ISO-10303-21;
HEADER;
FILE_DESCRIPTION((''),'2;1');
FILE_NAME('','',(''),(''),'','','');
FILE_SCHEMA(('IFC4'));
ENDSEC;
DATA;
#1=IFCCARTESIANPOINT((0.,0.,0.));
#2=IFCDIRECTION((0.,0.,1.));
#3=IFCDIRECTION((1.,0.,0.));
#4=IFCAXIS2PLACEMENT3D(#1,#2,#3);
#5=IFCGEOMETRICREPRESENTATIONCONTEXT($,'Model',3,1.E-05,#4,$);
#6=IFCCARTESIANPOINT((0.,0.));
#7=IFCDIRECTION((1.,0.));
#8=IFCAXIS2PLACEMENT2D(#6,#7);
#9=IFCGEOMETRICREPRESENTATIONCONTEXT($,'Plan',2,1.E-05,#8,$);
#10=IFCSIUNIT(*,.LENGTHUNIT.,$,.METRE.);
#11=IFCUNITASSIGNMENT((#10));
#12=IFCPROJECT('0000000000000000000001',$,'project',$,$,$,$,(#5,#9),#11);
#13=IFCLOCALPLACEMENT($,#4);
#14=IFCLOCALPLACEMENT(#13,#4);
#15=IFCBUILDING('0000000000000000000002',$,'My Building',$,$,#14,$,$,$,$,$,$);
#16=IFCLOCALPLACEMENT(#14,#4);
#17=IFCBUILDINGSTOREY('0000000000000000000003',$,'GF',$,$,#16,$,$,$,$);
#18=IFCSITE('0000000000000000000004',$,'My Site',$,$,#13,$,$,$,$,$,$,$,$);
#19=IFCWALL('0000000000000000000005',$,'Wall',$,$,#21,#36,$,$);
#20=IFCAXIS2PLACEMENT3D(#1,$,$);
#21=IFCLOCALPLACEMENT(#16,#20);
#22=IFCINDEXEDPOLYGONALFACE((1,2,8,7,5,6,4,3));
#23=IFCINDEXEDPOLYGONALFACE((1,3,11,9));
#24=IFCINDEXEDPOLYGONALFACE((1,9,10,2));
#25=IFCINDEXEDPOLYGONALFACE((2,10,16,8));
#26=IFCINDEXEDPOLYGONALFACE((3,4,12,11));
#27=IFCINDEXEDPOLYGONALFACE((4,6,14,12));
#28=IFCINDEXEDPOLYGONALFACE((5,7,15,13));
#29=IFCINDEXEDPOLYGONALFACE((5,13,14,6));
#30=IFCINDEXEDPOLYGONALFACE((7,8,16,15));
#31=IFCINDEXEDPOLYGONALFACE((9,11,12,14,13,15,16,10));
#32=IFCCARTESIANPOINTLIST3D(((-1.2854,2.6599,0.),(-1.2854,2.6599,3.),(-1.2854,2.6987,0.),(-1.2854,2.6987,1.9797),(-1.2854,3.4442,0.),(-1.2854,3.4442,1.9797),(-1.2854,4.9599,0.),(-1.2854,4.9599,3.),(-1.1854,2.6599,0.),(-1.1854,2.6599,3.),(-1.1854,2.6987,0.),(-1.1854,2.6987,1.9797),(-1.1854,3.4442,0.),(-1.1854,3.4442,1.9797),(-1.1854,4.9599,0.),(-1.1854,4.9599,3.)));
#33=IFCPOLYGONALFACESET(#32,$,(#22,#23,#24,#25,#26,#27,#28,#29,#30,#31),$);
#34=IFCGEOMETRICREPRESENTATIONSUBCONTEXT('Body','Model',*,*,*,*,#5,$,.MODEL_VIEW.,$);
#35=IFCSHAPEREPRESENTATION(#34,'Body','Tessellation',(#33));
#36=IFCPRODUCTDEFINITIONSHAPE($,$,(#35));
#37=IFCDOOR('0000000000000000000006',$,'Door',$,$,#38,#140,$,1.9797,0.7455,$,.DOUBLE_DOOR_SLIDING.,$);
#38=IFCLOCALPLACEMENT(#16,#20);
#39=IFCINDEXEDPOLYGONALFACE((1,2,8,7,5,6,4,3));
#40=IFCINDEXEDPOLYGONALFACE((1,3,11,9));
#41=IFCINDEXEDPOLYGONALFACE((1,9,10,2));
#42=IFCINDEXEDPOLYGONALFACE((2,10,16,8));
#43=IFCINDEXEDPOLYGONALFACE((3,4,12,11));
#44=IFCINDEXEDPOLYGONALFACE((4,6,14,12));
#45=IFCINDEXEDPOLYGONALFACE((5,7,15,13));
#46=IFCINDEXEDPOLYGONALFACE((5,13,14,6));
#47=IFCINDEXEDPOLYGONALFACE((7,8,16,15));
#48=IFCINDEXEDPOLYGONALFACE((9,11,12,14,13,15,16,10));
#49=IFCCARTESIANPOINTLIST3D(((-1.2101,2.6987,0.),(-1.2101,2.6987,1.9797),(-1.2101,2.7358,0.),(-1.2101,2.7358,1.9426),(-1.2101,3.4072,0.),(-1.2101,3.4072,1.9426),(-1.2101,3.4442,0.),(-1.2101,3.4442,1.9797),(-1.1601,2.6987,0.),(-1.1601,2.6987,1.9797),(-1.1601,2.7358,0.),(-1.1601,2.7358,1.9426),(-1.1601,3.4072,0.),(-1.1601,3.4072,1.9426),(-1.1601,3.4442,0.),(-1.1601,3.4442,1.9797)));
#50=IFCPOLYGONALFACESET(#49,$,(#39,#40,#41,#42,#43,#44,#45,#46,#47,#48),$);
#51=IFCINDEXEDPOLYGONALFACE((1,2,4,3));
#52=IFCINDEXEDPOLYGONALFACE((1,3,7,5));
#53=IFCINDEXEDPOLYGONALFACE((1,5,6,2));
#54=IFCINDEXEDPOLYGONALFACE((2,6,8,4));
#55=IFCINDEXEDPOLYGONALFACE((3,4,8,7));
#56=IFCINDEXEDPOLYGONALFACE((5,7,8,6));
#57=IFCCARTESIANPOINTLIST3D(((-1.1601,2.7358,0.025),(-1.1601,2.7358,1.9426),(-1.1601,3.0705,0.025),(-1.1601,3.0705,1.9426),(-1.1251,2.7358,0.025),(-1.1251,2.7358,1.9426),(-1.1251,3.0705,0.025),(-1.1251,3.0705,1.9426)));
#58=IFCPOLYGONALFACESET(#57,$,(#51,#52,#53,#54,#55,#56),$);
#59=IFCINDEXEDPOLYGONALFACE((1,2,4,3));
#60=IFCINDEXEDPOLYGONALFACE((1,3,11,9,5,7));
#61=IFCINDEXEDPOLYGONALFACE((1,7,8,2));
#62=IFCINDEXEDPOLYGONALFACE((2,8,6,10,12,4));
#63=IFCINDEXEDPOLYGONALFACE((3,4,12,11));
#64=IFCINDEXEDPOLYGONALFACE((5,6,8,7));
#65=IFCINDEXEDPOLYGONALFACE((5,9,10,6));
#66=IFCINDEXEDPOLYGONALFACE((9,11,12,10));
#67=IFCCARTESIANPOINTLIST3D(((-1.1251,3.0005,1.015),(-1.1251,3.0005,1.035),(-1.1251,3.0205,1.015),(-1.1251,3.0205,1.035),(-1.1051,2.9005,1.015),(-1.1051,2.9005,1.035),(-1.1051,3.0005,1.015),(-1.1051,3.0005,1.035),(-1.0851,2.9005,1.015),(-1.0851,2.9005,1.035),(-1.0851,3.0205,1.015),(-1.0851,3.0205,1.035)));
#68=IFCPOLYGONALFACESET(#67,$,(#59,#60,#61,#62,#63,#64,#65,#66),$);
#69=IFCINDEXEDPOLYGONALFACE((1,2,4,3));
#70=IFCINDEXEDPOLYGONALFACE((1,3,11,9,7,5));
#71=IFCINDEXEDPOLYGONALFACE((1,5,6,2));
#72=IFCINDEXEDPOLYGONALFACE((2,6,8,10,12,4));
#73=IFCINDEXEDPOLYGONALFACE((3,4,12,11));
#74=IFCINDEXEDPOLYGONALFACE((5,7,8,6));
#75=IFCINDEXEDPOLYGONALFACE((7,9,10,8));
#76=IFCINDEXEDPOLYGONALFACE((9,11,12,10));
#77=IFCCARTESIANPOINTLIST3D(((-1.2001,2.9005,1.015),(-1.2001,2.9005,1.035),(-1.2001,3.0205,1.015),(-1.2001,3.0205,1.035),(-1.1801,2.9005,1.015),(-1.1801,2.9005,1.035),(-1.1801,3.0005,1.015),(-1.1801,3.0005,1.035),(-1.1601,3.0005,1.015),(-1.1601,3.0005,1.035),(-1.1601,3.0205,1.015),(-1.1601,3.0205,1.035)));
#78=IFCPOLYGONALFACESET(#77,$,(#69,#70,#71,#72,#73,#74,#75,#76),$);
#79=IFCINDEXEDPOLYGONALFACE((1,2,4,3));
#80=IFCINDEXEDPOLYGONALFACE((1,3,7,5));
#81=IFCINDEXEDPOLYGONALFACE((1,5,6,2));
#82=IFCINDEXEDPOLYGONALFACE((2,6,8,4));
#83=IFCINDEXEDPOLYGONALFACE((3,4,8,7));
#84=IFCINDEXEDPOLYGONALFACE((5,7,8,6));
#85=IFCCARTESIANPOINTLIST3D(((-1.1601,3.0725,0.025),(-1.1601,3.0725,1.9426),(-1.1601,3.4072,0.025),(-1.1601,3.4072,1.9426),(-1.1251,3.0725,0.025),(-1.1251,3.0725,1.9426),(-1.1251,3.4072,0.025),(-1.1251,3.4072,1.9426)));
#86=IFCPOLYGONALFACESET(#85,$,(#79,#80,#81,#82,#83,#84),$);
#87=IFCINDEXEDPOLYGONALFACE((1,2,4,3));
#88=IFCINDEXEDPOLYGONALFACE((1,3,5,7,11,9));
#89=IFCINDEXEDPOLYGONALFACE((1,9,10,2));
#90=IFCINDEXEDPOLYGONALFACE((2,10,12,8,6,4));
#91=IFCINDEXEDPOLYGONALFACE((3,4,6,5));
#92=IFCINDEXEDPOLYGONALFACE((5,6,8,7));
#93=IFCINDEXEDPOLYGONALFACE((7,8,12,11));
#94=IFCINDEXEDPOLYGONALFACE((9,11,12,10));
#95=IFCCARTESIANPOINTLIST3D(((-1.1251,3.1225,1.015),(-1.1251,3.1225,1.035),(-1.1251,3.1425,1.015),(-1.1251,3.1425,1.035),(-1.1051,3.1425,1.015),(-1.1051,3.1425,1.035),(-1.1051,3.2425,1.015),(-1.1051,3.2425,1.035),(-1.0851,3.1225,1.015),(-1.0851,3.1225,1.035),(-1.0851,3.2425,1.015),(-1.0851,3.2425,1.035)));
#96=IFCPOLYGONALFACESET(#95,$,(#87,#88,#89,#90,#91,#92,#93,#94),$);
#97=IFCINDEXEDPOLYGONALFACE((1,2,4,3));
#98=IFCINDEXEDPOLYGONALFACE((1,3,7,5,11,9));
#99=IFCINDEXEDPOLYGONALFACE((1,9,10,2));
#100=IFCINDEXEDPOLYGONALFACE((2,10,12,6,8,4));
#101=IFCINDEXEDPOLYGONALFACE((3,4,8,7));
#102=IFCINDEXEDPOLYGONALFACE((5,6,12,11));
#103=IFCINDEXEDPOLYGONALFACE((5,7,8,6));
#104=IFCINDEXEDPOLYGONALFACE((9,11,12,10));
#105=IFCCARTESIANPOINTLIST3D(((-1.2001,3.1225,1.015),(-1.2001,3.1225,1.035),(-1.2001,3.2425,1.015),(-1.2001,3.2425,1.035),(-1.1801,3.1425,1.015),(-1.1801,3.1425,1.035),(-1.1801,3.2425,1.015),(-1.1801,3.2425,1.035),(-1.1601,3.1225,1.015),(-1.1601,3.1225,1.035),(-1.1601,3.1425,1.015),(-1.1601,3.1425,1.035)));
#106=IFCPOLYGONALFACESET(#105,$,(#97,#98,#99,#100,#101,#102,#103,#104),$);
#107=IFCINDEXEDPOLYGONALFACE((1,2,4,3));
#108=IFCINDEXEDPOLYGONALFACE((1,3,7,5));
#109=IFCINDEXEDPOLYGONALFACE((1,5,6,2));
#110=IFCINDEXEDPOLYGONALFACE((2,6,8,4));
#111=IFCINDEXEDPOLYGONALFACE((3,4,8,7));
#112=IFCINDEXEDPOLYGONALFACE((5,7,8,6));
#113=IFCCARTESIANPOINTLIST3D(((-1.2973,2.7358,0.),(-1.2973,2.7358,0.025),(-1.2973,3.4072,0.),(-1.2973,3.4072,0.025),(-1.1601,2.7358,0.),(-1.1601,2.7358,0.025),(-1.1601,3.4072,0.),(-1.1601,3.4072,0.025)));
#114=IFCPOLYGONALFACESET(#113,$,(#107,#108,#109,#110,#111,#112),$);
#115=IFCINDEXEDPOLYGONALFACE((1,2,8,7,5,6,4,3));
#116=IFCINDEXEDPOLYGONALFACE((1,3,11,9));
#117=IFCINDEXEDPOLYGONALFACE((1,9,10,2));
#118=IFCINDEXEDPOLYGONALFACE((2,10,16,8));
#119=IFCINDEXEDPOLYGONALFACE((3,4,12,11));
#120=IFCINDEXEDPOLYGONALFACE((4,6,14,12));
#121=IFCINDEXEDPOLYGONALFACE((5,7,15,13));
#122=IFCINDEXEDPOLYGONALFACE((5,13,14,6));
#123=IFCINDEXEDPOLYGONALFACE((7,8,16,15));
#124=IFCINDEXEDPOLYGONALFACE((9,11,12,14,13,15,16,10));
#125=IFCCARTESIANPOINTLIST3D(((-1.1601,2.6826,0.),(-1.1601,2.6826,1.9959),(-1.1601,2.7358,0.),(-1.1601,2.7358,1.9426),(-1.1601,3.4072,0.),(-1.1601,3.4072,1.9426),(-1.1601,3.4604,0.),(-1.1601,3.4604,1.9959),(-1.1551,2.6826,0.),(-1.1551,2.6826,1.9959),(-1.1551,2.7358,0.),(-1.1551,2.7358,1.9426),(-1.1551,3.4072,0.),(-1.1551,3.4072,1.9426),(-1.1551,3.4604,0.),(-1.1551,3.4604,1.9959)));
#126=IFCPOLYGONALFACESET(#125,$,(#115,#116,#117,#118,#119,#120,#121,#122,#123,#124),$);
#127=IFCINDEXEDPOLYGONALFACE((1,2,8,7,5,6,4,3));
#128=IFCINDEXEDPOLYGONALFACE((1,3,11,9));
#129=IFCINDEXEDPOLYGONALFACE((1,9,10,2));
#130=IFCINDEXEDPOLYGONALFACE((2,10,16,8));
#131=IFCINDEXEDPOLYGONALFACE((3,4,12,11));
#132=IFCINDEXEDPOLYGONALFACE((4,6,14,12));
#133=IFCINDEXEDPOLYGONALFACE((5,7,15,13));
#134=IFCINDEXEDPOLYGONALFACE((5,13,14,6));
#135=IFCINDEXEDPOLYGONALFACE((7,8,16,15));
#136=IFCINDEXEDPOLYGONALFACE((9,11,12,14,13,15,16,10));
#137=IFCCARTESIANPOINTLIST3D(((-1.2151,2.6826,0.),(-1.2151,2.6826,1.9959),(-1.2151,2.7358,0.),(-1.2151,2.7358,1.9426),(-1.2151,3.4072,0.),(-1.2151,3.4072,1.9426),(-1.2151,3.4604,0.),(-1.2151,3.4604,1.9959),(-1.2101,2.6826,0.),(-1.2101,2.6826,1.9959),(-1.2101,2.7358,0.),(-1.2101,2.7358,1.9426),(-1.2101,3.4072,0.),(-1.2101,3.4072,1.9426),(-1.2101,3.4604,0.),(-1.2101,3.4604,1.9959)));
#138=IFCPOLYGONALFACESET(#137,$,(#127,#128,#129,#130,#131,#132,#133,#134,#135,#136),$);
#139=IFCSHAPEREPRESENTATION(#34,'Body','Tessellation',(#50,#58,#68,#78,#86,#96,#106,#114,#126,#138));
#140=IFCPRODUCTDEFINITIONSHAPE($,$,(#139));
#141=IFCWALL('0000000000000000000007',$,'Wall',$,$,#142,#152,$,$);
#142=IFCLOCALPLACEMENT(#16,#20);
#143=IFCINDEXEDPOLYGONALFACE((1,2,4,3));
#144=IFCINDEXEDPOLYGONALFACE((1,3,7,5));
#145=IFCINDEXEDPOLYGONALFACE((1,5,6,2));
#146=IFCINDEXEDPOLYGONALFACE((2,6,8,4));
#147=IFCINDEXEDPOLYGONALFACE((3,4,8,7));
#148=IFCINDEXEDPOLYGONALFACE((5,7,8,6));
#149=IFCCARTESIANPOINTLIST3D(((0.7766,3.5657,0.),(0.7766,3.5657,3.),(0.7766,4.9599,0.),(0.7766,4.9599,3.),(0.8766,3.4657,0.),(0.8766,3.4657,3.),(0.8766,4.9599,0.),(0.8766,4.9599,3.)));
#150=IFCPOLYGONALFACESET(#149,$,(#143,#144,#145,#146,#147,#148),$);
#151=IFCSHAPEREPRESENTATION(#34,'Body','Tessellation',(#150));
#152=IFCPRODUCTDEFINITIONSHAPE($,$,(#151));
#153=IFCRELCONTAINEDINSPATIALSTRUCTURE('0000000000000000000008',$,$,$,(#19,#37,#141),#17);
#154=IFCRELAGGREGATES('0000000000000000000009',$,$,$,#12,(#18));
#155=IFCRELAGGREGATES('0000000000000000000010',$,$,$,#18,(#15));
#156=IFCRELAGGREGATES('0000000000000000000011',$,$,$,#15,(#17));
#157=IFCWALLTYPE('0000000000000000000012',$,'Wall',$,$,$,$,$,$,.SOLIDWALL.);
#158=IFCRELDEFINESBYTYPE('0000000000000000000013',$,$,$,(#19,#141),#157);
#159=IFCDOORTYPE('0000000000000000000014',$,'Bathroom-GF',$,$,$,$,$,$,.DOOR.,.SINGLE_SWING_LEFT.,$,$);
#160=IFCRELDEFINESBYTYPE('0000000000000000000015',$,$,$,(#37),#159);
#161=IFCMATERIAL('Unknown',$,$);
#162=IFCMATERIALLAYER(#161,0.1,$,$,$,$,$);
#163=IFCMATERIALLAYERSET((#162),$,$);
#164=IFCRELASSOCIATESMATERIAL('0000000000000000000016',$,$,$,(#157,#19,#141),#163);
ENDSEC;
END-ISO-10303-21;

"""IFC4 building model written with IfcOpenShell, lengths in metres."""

from ifc_helpers import new_model, entity, si_unit, frame, origin_with_axes, origin_2d_with_axis, place, context, subcontext, project, spatial, line, indexed_curve, outline, extrude, shape, source, transform, mapped, material, layer, layer_set, layer_usage, type_object, type_shapes, element, fill, save


model = new_model("IFC4")

# Units and contexts
model_context = context("Model", 3, precision=1e-05, world=origin_with_axes())
plan_context = context("Plan", 2, precision=1e-05, world=origin_2d_with_axis())
body_context_1 = subcontext(model_context, "Body", "Model", "MODEL_VIEW")
body_context_2 = subcontext(plan_context, "Body", "Plan", "PLAN_VIEW")
ifc_project = project(units=[si_unit("LENGTHUNIT", "METRE")], contexts=[model_context, plan_context])

# Site, building, storey
site_placement = place(None, origin_with_axes())
site = spatial("IfcSite", under=ifc_project, at=site_placement, Name="My Site")
building_placement = place(site_placement, origin_with_axes())
building = spatial("IfcBuilding", under=site, at=building_placement, Name="My Building")
storey_placement = place(building_placement, origin_with_axes())
storey = spatial("IfcBuildingStorey", under=building, at=storey_placement, Name="GF")

# Shared definitions
ifc_material = material(Name="Unknown")

# Shared definitions
ifc_layer_1 = layer(ifc_material, 0.1)
ifc_layer_set_1 = layer_set([ifc_layer_1])
wall_type = type_object("IfcWallType", Name="Wall", PredefinedType="SOLIDWALL", material=ifc_layer_set_1)

# Wall, opening, door
ifc_layer_usage_1 = layer_usage(ifc_layer_set_1, "AXIS2", "POSITIVE", 0.0)
wall_1_placement = place(storey_placement, frame((-1.1854, 2.6599, 0.0), z_axis=(0.0, 0.0, 1.0), x_axis=(0.0, 1.0, 0.0)))
wall_1 = element("IfcWall", 1, at=wall_1_placement, inside=storey, type_object=wall_type, material=ifc_layer_usage_1, Name="Wall", context=body_context_1, shape_type="SweptSolid", body=[
    extrude(outline(indexed_curve([(0.0, 0.0), (0.0, 0.1), (2.3, 0.1), (2.3, 0.0)], segments=[line(1, 2, 3, 4, 1)])), origin_with_axes(), (0.0, 0.0, 1.0), 3.0),
])
shared_shape_1 = source(origin_with_axes(), body_context_1, "Body", "SweptSolid", [
    extrude(outline(indexed_curve([(0.0, 0.0), (0.7455, 0.0), (0.7455, 1.9797), (0.0, 1.9797)], segments=[line(1, 2, 3, 4, 1)])), frame((0.0, -0.6, 0.0), z_axis=(0.0, -1.0, 0.0), x_axis=(1.0, 0.0, 0.0)), (0.0, 0.0, -1.0), 1.2),
])
opening_1_placement = place(wall_1_placement, frame((0.0388, -0.0253, 0.0), z_axis=(0.0, 0.0, 1.0), x_axis=(1.0, 0.0, 0.0)))
opening_1 = element("IfcOpeningElement", 2, at=opening_1_placement, cuts=wall_1, PredefinedType="OPENING", context=body_context_1, shape_type="MappedRepresentation", body=[
    mapped(shared_shape_1, transform((0.0, 0.0, 0.0), x_axis=(1.0, 0.0, 0.0), y_axis=(0.0, 1.0, 0.0), z_axis=(0.0, 0.0, 1.0), scale=1.0)),
])
door_type_1 = type_object("IfcDoorType", Name="Bathroom-GF", OperationType="SINGLE_SWING_LEFT", PredefinedType="DOOR")
shared_shape_2 = source(origin_with_axes(), body_context_1, "Body", "SweptSolid", [
    extrude(outline(indexed_curve([(0.0, 0.0), (0.0, 1.9797), (0.7455, 1.9797), (0.7455, 0.0), (0.7084, 0.0), (0.7084, 1.9426), (0.0371, 1.9426), (0.0371, 0.0)], segments=[line(1, 2, 3, 4, 5, 6, 7, 8, 1)])), frame((0.0, 0.0, 0.0), z_axis=(0.0, -1.0, 0.0), x_axis=(1.0, 0.0, 0.0)), (0.0, 0.0, -1.0), 0.05),
    extrude(outline(indexed_curve([(0.0, 0.0), (0.3347, 0.0), (0.3347, 0.035), (0.0, 0.035)], segments=[line(1, 2, 3, 4, 1)])), frame((0.0371, -0.035, 0.025), z_axis=(0.0, 0.0, 1.0), x_axis=(1.0, 0.0, 0.0)), (0.0, 0.0, 1.0), 1.9176),
    extrude(outline(indexed_curve([(0.0, 0.0), (0.0, -0.04), (-0.12, -0.04), (-0.12, -0.02), (-0.02, -0.02), (-0.02, 0.0)], segments=[line(1, 2, 3, 4, 5, 6, 1)])), frame((0.3218, -0.035, 1.015), z_axis=(0.0, 0.0, 1.0), x_axis=(1.0, 0.0, 0.0)), (0.0, 0.0, 1.0), 0.02),
    extrude(outline(indexed_curve([(0.0, 0.0), (0.0, 0.04), (-0.12, 0.04), (-0.12, 0.02), (-0.02, 0.02), (-0.02, 0.0)], segments=[line(1, 2, 3, 4, 5, 6, 1)])), frame((0.3218, 0.0, 1.015), z_axis=(0.0, 0.0, 1.0), x_axis=(1.0, 0.0, 0.0)), (0.0, 0.0, 1.0), 0.02),
    extrude(outline(indexed_curve([(0.0, 0.0), (-0.3347, 0.0), (-0.3347, 0.035), (0.0, 0.035)], segments=[line(1, 2, 3, 4, 1)])), frame((0.7084, -0.035, 0.025), z_axis=(0.0, 0.0, 1.0), x_axis=(1.0, 0.0, 0.0)), (0.0, 0.0, 1.0), 1.9176),
    extrude(outline(indexed_curve([(0.0, 0.0), (0.0, -0.04), (0.12, -0.04), (0.12, -0.02), (0.02, -0.02), (0.02, 0.0)], segments=[line(1, 2, 3, 4, 5, 6, 1)])), frame((0.4238, -0.035, 1.015), z_axis=(0.0, 0.0, 1.0), x_axis=(1.0, 0.0, 0.0)), (0.0, 0.0, 1.0), 0.02),
    extrude(outline(indexed_curve([(0.0, 0.0), (0.0, 0.04), (0.12, 0.04), (0.12, 0.02), (0.02, 0.02), (0.02, 0.0)], segments=[line(1, 2, 3, 4, 5, 6, 1)])), frame((0.4238, 0.0, 1.015), z_axis=(0.0, 0.0, 1.0), x_axis=(1.0, 0.0, 0.0)), (0.0, 0.0, 1.0), 0.02),
    extrude(outline(indexed_curve([(0.0, 0.0), (0.6713, 0.0), (0.6713, 0.1372), (0.0, 0.1372)], segments=[line(1, 2, 3, 4, 1)])), frame((0.0371, 0.0, 0.0), z_axis=(0.0, 0.0, 1.0), x_axis=(1.0, 0.0, 0.0)), (0.0, 0.0, 1.0), 0.025),
    extrude(outline(indexed_curve([(0.0, 0.0), (0.0, 1.9959), (0.7778, 1.9959), (0.7778, 0.0), (0.7246, 0.0), (0.7246, 1.9426), (0.0532, 1.9426), (0.0532, 0.0)], segments=[line(1, 2, 3, 4, 5, 6, 7, 8, 1)])), frame((-0.0162, -0.005, 0.0), z_axis=(0.0, -1.0, 0.0), x_axis=(1.0, 0.0, 0.0)), (0.0, 0.0, -1.0), 0.005),
    extrude(outline(indexed_curve([(0.0, 0.0), (0.0, 1.9959), (0.7778, 1.9959), (0.7778, 0.0), (0.7246, 0.0), (0.7246, 1.9426), (0.0532, 1.9426), (0.0532, 0.0)], segments=[line(1, 2, 3, 4, 5, 6, 7, 8, 1)])), frame((-0.0162, 0.05, 0.0), z_axis=(0.0, -1.0, 0.0), x_axis=(1.0, 0.0, 0.0)), (0.0, 0.0, -1.0), 0.005),
])
shared_shape_3 = source(origin_with_axes(), body_context_2, "Body", "Curve2D", [
    entity("IfcIndexedPolyCurve", entity("IfcCartesianPointList2D", [[0.0, 0.0], [0.0371, 0.0], [0.0371, 0.05], [0.0, 0.05]]), [entity("IfcLineIndex", [1, 2, 3, 4, 1])]),
    entity("IfcIndexedPolyCurve", entity("IfcCartesianPointList2D", [[0.7455, 0.0], [0.7084, 0.0], [0.7084, 0.05], [0.7455, 0.05]]), [entity("IfcLineIndex", [1, 2, 3, 4, 1])]),
    entity("IfcIndexedPolyCurve", entity("IfcCartesianPointList2D", [[-0.1307, -0.035], [0.2049, -0.035], [0.2049, 0.0], [-0.1307, 0.0]]), [entity("IfcLineIndex", [1, 2, 3, 4, 1])]),
    entity("IfcIndexedPolyCurve", entity("IfcCartesianPointList2D", [[0.8763, -0.035], [0.5406, -0.035], [0.5406, 0.0], [0.8763, 0.0]]), [entity("IfcLineIndex", [1, 2, 3, 4, 1])]),
])
type_shapes(door_type_1, [shared_shape_2, shared_shape_3])
door_1_placement = place(opening_1_placement, frame((0.0, 0.0, 0.0), z_axis=(0.0, 0.0, 1.0), x_axis=(1.0, 0.0, 0.0)))
door_1 = element("IfcDoor", 3, at=door_1_placement, inside=storey, type_object=door_type_1, Name="Door", OperationType="DOUBLE_DOOR_SLIDING", OverallHeight=1.9797, OverallWidth=0.7455, shapes=[
    shape(body_context_1, "Body", "MappedRepresentation", [mapped(shared_shape_2, transform((0.0, 0.0, 0.0), x_axis=(1.0, 0.0, 0.0), y_axis=(0.0, 1.0, 0.0), z_axis=(0.0, 0.0, 1.0), scale=1.0))]),
    shape(body_context_2, "Body", "MappedRepresentation", [mapped(shared_shape_3, transform((0.0, 0.0, 0.0), x_axis=(1.0, 0.0, 0.0), y_axis=(0.0, 1.0, 0.0), z_axis=(0.0, 0.0, 1.0), scale=1.0))]),
])
fill(opening_1, door_1)

# Wall
ifc_layer_usage_2 = layer_usage(ifc_layer_set_1, "AXIS2", "POSITIVE", 0.0)
wall_2_placement = place(storey_placement, frame((0.7766, 5.0599, 0.0), z_axis=(0.0, 0.0, 1.0), x_axis=(0.0, -1.0, 0.0)))
element("IfcWall", 4, at=wall_2_placement, inside=storey, type_object=wall_type, material=ifc_layer_usage_2, Name="Wall", context=body_context_1, shape_type="SweptSolid", body=[
    extrude(outline(indexed_curve([(0.1, 0.0), (0.1, 0.1), (1.5942, 0.1), (1.4942, 0.0)], segments=[line(1, 2, 3, 4, 1)])), origin_with_axes(), (0.0, 0.0, 1.0), 3.0),
])

save(model, "model.ifc")
